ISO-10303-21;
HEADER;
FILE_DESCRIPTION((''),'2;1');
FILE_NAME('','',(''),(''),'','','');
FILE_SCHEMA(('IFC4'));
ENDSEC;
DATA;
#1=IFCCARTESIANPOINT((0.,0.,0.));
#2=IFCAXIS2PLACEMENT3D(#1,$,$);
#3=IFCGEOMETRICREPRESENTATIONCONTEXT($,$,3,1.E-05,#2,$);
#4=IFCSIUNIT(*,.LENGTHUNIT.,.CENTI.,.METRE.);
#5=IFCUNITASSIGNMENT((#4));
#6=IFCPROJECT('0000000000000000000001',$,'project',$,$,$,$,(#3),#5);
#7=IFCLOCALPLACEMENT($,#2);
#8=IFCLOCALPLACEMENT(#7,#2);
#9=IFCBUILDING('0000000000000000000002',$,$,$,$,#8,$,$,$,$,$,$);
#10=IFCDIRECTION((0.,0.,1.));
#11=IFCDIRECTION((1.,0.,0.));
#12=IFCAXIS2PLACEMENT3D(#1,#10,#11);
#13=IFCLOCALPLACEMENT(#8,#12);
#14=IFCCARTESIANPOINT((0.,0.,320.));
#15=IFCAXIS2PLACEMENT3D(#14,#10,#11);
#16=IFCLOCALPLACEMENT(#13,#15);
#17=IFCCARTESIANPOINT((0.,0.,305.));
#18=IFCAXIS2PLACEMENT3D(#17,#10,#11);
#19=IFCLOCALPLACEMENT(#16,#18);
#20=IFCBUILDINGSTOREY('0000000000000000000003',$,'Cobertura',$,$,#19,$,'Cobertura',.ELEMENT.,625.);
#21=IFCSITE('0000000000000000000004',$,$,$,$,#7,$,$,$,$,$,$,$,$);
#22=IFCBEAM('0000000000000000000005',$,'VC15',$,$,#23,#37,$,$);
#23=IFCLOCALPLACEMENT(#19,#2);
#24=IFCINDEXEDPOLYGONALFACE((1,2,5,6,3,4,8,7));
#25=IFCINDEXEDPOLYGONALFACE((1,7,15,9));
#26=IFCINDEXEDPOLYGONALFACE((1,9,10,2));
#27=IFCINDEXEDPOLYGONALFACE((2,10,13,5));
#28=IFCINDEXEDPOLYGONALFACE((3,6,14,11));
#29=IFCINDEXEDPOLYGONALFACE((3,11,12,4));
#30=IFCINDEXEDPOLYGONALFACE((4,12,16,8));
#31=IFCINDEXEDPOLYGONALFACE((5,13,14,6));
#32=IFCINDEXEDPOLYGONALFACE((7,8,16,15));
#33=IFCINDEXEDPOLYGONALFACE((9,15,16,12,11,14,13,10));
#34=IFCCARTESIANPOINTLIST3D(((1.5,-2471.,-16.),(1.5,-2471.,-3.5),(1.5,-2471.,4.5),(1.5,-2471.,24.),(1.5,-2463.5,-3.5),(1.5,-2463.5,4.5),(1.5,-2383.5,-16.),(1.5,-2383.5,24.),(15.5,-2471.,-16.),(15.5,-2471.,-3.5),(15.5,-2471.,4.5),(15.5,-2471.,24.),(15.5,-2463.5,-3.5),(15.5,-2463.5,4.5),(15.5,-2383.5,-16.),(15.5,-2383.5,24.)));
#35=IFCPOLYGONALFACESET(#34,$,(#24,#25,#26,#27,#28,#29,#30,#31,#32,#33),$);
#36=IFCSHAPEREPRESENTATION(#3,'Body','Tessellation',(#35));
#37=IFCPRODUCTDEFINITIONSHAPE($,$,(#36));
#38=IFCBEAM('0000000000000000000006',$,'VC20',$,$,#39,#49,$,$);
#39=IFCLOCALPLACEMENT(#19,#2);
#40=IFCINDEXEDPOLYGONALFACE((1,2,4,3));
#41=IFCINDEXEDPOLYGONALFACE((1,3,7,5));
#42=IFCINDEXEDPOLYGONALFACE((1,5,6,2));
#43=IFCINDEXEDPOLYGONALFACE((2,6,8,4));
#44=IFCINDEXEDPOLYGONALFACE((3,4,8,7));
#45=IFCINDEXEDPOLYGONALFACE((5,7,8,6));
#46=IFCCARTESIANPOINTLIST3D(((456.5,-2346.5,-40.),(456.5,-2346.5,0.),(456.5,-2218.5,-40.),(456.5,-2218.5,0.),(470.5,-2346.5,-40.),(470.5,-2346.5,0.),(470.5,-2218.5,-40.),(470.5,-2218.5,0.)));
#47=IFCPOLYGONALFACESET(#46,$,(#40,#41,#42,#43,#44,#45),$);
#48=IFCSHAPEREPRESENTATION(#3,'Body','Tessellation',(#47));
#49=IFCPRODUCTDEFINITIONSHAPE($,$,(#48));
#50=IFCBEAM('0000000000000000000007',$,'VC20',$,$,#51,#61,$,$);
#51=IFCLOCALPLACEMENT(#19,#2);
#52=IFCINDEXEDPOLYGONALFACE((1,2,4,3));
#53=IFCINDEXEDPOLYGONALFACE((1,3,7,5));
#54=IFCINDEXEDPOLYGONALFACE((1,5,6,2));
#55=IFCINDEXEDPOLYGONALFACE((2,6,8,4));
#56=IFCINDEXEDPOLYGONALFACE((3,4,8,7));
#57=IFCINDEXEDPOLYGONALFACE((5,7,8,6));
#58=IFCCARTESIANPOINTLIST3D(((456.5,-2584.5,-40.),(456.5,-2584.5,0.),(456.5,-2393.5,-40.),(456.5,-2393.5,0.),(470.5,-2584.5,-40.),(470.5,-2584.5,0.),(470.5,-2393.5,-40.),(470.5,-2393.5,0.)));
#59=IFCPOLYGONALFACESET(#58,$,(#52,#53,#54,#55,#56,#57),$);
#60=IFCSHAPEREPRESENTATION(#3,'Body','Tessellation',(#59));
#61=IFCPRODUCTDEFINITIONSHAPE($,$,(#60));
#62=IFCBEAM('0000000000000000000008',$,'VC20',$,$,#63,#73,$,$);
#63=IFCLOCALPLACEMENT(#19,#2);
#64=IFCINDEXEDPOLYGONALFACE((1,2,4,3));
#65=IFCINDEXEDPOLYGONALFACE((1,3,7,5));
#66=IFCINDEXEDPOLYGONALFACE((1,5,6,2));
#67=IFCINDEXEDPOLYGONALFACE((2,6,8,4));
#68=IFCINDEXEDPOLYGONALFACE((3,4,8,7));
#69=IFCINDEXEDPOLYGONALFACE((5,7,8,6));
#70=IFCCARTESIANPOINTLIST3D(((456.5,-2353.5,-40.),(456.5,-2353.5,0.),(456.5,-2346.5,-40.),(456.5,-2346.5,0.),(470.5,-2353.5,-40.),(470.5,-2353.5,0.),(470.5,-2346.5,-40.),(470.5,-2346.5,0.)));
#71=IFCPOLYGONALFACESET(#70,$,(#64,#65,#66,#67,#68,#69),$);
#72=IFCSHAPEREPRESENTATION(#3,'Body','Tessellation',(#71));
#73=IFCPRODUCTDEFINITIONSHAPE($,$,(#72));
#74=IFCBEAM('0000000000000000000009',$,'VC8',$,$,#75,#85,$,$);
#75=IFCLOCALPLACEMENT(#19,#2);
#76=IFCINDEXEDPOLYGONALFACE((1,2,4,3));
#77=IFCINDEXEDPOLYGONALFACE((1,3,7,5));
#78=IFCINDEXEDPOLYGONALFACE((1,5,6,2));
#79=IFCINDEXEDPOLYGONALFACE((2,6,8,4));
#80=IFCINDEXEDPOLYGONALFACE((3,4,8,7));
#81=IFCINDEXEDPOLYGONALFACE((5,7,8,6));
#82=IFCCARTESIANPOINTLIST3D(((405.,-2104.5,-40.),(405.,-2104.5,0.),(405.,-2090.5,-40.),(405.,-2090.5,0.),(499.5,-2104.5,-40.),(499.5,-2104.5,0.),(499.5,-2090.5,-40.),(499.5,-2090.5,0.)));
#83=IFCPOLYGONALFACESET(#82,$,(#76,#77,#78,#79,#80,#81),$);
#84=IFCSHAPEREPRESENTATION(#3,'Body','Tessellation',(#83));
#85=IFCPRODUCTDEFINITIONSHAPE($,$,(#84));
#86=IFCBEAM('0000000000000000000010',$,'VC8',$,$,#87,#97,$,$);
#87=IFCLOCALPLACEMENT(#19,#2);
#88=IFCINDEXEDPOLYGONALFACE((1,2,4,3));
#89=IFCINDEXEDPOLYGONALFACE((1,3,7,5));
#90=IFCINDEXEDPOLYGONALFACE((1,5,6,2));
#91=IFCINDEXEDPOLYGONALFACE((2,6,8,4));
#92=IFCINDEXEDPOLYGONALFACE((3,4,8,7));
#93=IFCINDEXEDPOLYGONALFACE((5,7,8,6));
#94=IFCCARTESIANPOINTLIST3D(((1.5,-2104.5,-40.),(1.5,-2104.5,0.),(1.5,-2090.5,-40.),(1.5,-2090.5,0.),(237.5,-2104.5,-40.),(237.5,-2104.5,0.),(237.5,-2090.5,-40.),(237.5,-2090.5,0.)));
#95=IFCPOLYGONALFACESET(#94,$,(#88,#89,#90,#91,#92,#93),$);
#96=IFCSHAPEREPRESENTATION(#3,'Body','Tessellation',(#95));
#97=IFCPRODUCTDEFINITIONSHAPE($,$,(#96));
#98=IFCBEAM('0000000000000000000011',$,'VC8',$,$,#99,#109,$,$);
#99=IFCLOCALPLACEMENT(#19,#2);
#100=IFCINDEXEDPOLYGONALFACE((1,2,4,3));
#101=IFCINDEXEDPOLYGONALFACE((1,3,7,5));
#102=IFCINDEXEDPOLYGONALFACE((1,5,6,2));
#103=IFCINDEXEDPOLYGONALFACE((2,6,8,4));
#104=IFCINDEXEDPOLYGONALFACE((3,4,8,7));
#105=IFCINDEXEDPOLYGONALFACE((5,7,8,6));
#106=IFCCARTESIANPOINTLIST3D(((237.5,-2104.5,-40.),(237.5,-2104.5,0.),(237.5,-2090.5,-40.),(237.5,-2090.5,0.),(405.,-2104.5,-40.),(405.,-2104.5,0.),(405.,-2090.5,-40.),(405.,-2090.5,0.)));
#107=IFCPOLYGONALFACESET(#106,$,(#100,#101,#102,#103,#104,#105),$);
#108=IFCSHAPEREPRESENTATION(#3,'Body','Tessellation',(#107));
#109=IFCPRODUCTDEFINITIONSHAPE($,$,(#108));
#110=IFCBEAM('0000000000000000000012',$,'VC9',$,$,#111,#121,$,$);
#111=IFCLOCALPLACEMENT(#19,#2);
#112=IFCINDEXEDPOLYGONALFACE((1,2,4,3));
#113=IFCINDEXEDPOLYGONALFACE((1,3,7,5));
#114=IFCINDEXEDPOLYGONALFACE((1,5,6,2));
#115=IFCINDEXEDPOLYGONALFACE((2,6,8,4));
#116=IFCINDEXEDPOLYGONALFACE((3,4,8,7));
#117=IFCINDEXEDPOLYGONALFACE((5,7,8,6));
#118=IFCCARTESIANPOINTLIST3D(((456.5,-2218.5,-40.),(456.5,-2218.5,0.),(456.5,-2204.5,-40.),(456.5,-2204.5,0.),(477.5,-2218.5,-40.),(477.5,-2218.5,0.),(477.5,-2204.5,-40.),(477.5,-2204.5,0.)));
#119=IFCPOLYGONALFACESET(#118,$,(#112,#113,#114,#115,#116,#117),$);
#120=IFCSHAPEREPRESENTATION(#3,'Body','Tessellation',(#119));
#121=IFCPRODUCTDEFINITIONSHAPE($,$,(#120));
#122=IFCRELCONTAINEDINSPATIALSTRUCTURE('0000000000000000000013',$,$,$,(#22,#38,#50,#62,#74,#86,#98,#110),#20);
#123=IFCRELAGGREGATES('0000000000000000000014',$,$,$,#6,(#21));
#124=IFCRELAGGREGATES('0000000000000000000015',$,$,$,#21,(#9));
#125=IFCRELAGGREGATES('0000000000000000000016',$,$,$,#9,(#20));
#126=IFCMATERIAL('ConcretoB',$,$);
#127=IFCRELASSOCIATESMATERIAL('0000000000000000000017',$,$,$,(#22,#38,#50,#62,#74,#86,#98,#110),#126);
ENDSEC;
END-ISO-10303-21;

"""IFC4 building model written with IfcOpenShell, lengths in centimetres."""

from ifc_helpers import new_model, si_unit, frame, origin, origin_with_axes, place, context, project, spatial, polyline, outline, extrude, material, element, save


model = new_model("IFC4")

# Units and contexts
context_of_model = context(None, 3, precision=1e-05, world=origin())
ifc_project = project(units=[si_unit("LENGTHUNIT", "METRE", prefix="CENTI")], contexts=[context_of_model])

# Site, building, storey
site_placement = place(None, origin())
site = spatial("IfcSite", under=ifc_project, at=site_placement)
building_placement = place(site_placement, origin())
building = spatial("IfcBuilding", under=site, at=building_placement)
placement_1 = place(building_placement, origin_with_axes())
placement_2 = place(placement_1, frame((0.0, 0.0, 320.0), z_axis=(0.0, 0.0, 1.0), x_axis=(1.0, 0.0, 0.0)))
storey_placement = place(placement_2, frame((0.0, 0.0, 305.0), z_axis=(0.0, 0.0, 1.0), x_axis=(1.0, 0.0, 0.0)))
storey = spatial("IfcBuildingStorey", under=building, at=storey_placement, Name="Cobertura", LongName="Cobertura", CompositionType="ELEMENT", Elevation=625.0)

# Shared definitions
ifc_material = material(Name="ConcretoB")

# Beam, opening
beam_1_placement = place(storey_placement, frame((8.5, -2427.25, 24.0), z_axis=(0.0, 0.0, 1.0), x_axis=(1.0, 0.0, 0.0)))
beam_1 = element("IfcBeam", 1, at=beam_1_placement, inside=storey, material=ifc_material, Name="VC15", context=context_of_model, shape_type="SolidModel", body=[
    extrude(outline(polyline([(-7.0, -20.0), (7.0, -20.0), (7.0, 20.0), (-7.0, 20.0), (-7.0, -20.0)])), frame((0.0, -43.75, -20.0), z_axis=(0.0, 1.0, 0.0), x_axis=(1.0, 0.0, 0.0)), (0.0, 0.0, 1.0), 87.5),
])
opening_1_placement = place(storey_placement, frame((0.0, 0.0, -625.0), z_axis=(0.0, 0.0, 1.0), x_axis=(1.0, 0.0, 0.0)))
element("IfcOpeningElement", 2, at=opening_1_placement, cuts=beam_1, material=ifc_material, context=context_of_model, shape_type="SweptSolid", body=[
    extrude(outline(polyline([(7.5, 4.0), (-7.5, 4.0), (-7.5, -4.0), (7.5, -4.0), (7.5, 4.0)])), frame((15.5, -2471.0, 625.5), z_axis=(-1.0, 0.0, 0.0), x_axis=(0.0, -1.0, 0.0)), (0.0, 0.0, 1.0), 14.0),
])

# Beams
beam_2_placement = place(storey_placement, frame((463.5, -2282.5, 0.0), z_axis=(0.0, 0.0, 1.0), x_axis=(1.0, 0.0, 0.0)))
element("IfcBeam", 3, at=beam_2_placement, inside=storey, material=ifc_material, Name="VC20", context=context_of_model, shape_type="SolidModel", body=[
    extrude(outline(polyline([(-7.0, -20.0), (7.0, -20.0), (7.0, 20.0), (-7.0, 20.0), (-7.0, -20.0)])), frame((0.0, -64.0, -20.0), z_axis=(0.0, 1.0, 0.0), x_axis=(1.0, 0.0, 0.0)), (0.0, 0.0, 1.0), 128.0),
])
beam_3_placement = place(storey_placement, frame((463.5, -2489.0, 0.0), z_axis=(0.0, 0.0, 1.0), x_axis=(1.0, 0.0, 0.0)))
element("IfcBeam", 4, at=beam_3_placement, inside=storey, material=ifc_material, Name="VC20", context=context_of_model, shape_type="SolidModel", body=[
    extrude(outline(polyline([(-7.0, -20.0), (7.0, -20.0), (7.0, 20.0), (-7.0, 20.0), (-7.0, -20.0)])), frame((0.0, -95.5, -20.0), z_axis=(0.0, 1.0, 0.0), x_axis=(1.0, 0.0, 0.0)), (0.0, 0.0, 1.0), 191.0),
])
beam_4_placement = place(storey_placement, frame((463.5, -2350.0, 0.0), z_axis=(0.0, 0.0, 1.0), x_axis=(1.0, 0.0, 0.0)))
element("IfcBeam", 5, at=beam_4_placement, inside=storey, material=ifc_material, Name="VC20", context=context_of_model, shape_type="SolidModel", body=[
    extrude(outline(polyline([(-7.0, -20.0), (7.0, -20.0), (7.0, 20.0), (-7.0, 20.0), (-7.0, -20.0)])), frame((0.0, -3.5, -20.0), z_axis=(0.0, 1.0, 0.0), x_axis=(1.0, 0.0, 0.0)), (0.0, 0.0, 1.0), 7.0),
])
beam_5_placement = place(storey_placement, frame((452.25, -2097.5, 0.0), z_axis=(0.0, 0.0, 1.0), x_axis=(1.0, 0.0, 0.0)))
element("IfcBeam", 6, at=beam_5_placement, inside=storey, material=ifc_material, Name="VC8", context=context_of_model, shape_type="SolidModel", body=[
    extrude(outline(polyline([(-7.0, -20.0), (7.0, -20.0), (7.0, 20.0), (-7.0, 20.0), (-7.0, -20.0)])), frame((-47.25, 0.0, -20.0), z_axis=(1.0, 0.0, 0.0), x_axis=(0.0, -1.0, 0.0)), (0.0, 0.0, 1.0), 94.5),
])
beam_6_placement = place(storey_placement, frame((119.5, -2097.5, 0.0), z_axis=(0.0, 0.0, 1.0), x_axis=(1.0, 0.0, 0.0)))
element("IfcBeam", 7, at=beam_6_placement, inside=storey, material=ifc_material, Name="VC8", context=context_of_model, shape_type="SolidModel", body=[
    extrude(outline(polyline([(-7.0, -20.0), (7.0, -20.0), (7.0, 20.0), (-7.0, 20.0), (-7.0, -20.0)])), frame((-118.0, 0.0, -20.0), z_axis=(1.0, 0.0, 0.0), x_axis=(0.0, -1.0, 0.0)), (0.0, 0.0, 1.0), 236.0),
])
beam_7_placement = place(storey_placement, frame((321.25, -2097.5, 0.0), z_axis=(0.0, 0.0, 1.0), x_axis=(1.0, 0.0, 0.0)))
element("IfcBeam", 8, at=beam_7_placement, inside=storey, material=ifc_material, Name="VC8", context=context_of_model, shape_type="SolidModel", body=[
    extrude(outline(polyline([(-7.0, -20.0), (7.0, -20.0), (7.0, 20.0), (-7.0, 20.0), (-7.0, -20.0)])), frame((-83.75, 0.0, -20.0), z_axis=(1.0, 0.0, 0.0), x_axis=(0.0, -1.0, 0.0)), (0.0, 0.0, 1.0), 167.5),
])
beam_8_placement = place(storey_placement, frame((467.0, -2211.5, 0.0), z_axis=(0.0, 0.0, 1.0), x_axis=(1.0, 0.0, 0.0)))
element("IfcBeam", 9, at=beam_8_placement, inside=storey, material=ifc_material, Name="VC9", context=context_of_model, shape_type="SolidModel", body=[
    extrude(outline(polyline([(-7.0, -20.0), (7.0, -20.0), (7.0, 20.0), (-7.0, 20.0), (-7.0, -20.0)])), frame((-10.5, 0.0, -20.0), z_axis=(1.0, 0.0, 0.0), x_axis=(0.0, -1.0, 0.0)), (0.0, 0.0, 1.0), 21.0),
])

save(model, "model.ifc")
